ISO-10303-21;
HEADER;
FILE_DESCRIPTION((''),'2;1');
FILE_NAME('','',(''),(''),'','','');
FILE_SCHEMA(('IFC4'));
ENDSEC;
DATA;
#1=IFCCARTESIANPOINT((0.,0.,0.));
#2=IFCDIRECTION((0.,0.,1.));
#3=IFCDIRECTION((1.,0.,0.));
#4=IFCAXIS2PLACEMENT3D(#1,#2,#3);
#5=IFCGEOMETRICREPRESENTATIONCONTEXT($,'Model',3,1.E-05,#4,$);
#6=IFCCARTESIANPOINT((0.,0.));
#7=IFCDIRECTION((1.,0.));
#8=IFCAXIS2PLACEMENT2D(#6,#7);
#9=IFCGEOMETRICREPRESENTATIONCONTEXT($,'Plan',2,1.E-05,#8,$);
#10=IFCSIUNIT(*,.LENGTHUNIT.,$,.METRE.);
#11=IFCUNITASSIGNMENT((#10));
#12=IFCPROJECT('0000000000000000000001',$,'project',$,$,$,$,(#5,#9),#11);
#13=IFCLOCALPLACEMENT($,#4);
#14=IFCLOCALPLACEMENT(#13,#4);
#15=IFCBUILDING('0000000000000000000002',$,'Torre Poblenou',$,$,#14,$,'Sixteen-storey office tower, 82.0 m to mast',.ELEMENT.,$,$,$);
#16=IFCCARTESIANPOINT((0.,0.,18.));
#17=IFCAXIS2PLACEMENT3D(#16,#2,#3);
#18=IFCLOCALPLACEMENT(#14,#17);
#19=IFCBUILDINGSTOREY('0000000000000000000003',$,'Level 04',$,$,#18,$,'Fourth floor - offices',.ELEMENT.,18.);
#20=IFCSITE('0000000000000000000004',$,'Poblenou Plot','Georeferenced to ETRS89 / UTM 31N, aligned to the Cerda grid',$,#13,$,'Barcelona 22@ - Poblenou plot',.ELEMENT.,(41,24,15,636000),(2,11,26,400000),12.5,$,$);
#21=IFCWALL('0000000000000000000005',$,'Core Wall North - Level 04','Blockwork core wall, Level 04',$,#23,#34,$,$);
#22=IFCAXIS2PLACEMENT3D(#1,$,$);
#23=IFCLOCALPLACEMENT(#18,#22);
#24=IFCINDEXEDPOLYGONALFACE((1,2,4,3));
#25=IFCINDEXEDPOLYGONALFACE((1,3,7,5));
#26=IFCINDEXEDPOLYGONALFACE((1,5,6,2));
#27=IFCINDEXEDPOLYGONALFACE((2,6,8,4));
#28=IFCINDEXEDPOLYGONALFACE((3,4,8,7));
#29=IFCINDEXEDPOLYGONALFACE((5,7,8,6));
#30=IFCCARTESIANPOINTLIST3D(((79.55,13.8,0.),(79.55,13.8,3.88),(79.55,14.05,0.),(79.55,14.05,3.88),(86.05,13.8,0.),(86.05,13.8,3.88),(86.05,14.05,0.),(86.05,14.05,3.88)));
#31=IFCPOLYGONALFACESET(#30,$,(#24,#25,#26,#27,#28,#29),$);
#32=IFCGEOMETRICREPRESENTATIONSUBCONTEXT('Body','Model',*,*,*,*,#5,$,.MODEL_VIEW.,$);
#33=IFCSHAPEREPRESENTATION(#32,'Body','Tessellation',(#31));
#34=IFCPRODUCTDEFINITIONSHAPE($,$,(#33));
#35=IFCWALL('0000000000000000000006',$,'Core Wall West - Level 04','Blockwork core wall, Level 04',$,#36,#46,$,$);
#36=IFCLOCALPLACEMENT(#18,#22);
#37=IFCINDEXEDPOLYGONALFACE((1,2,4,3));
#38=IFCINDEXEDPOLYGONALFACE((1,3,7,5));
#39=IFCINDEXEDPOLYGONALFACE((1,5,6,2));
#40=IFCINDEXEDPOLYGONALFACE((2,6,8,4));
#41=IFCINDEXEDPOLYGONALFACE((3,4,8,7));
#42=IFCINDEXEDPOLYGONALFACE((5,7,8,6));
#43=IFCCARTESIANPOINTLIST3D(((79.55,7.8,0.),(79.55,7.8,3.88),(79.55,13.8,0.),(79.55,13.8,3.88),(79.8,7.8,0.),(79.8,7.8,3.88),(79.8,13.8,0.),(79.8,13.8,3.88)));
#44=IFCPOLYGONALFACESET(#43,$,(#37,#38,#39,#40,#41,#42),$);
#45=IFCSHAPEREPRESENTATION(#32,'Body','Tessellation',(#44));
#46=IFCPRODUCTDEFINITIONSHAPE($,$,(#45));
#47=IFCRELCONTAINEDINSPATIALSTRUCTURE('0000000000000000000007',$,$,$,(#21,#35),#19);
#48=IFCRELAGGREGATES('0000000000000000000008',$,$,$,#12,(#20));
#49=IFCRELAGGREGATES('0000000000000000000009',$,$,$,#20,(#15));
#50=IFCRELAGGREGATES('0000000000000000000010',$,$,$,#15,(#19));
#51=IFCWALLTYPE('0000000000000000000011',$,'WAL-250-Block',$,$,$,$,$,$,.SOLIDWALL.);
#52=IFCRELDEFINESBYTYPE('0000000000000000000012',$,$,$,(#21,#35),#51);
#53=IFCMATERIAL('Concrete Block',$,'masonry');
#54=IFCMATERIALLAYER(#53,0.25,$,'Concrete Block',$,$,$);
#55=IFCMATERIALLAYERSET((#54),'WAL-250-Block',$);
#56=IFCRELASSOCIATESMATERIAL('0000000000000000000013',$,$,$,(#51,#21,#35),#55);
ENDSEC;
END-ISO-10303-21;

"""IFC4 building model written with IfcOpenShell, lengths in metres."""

from ifc_helpers import new_model, si_unit, frame, origin_with_axes, origin_2d_with_axis, place, context, subcontext, project, spatial, line, indexed_curve, outline, extrude, material, layer, layer_set, layer_usage, type_object, element, save


model = new_model("IFC4")

# Units and contexts
model_context = context("Model", 3, precision=1e-05, world=origin_with_axes())
plan_context = context("Plan", 2, precision=1e-05, world=origin_2d_with_axis())
body_context = subcontext(model_context, "Body", "Model", "MODEL_VIEW")
ifc_project = project(units=[si_unit("LENGTHUNIT", "METRE")], contexts=[model_context, plan_context])

# Site, building, storey
site_placement = place(None, origin_with_axes())
site = spatial("IfcSite", under=ifc_project, at=site_placement, Name="Poblenou Plot", Description="Georeferenced to ETRS89 / UTM 31N, aligned to the Cerda grid", LongName="Barcelona 22@ - Poblenou plot", CompositionType="ELEMENT", RefLatitude=(41, 24, 15, 636000), RefLongitude=(2, 11, 26, 400000), RefElevation=12.5)
building_placement = place(site_placement, origin_with_axes())
building = spatial("IfcBuilding", under=site, at=building_placement, Name="Torre Poblenou", LongName="Sixteen-storey office tower, 82.0 m to mast", CompositionType="ELEMENT")
storey_placement = place(building_placement, frame((0.0, 0.0, 18.0), z_axis=(0.0, 0.0, 1.0), x_axis=(1.0, 0.0, 0.0)))
storey = spatial("IfcBuildingStorey", under=building, at=storey_placement, Name="Level 04", LongName="Fourth floor - offices", CompositionType="ELEMENT", Elevation=18.0)

# Walls
ifc_material_1 = material(Name="Concrete Block", Category="masonry")
ifc_layer_1 = layer(ifc_material_1, 0.25, Name="Concrete Block")
ifc_layer_set_1 = layer_set([ifc_layer_1], Name="WAL-250-Block")
ifc_layer_usage_1 = layer_usage(ifc_layer_set_1, "AXIS2", "POSITIVE", 0.0)
wall_type = type_object("IfcWallType", Name="WAL-250-Block", PredefinedType="SOLIDWALL", material=ifc_layer_set_1)
wall_1_placement = place(storey_placement, frame((79.55, 13.8, 0.0), z_axis=(0.0, 0.0, 1.0), x_axis=(1.0, 0.0, 0.0)))
element("IfcWall", 1, at=wall_1_placement, inside=storey, type_object=wall_type, material=ifc_layer_usage_1, Name="Core Wall North - Level 04", Description="Blockwork core wall, Level 04", context=body_context, shape_type="SweptSolid", body=[
    extrude(outline(indexed_curve([(0.0, 0.0), (6.5, 0.0), (6.5, 0.25), (0.0, 0.25)], segments=[line(1, 2, 3, 4, 1)])), origin_with_axes(), (0.0, 0.0, 1.0), 3.88),
])
ifc_layer_usage_2 = layer_usage(ifc_layer_set_1, "AXIS2", "POSITIVE", 0.0)
wall_2_placement = place(storey_placement, frame((79.8, 7.8, 0.0), z_axis=(0.0, 0.0, 1.0), x_axis=(0.0, 1.0, 0.0)))
element("IfcWall", 2, at=wall_2_placement, inside=storey, type_object=wall_type, material=ifc_layer_usage_2, Name="Core Wall West - Level 04", Description="Blockwork core wall, Level 04", context=body_context, shape_type="SweptSolid", body=[
    extrude(outline(indexed_curve([(0.0, 0.0), (6.0, 0.0), (6.0, 0.25), (0.0, 0.25)], segments=[line(1, 2, 3, 4, 1)])), origin_with_axes(), (0.0, 0.0, 1.0), 3.88),
])

save(model, "model.ifc")
